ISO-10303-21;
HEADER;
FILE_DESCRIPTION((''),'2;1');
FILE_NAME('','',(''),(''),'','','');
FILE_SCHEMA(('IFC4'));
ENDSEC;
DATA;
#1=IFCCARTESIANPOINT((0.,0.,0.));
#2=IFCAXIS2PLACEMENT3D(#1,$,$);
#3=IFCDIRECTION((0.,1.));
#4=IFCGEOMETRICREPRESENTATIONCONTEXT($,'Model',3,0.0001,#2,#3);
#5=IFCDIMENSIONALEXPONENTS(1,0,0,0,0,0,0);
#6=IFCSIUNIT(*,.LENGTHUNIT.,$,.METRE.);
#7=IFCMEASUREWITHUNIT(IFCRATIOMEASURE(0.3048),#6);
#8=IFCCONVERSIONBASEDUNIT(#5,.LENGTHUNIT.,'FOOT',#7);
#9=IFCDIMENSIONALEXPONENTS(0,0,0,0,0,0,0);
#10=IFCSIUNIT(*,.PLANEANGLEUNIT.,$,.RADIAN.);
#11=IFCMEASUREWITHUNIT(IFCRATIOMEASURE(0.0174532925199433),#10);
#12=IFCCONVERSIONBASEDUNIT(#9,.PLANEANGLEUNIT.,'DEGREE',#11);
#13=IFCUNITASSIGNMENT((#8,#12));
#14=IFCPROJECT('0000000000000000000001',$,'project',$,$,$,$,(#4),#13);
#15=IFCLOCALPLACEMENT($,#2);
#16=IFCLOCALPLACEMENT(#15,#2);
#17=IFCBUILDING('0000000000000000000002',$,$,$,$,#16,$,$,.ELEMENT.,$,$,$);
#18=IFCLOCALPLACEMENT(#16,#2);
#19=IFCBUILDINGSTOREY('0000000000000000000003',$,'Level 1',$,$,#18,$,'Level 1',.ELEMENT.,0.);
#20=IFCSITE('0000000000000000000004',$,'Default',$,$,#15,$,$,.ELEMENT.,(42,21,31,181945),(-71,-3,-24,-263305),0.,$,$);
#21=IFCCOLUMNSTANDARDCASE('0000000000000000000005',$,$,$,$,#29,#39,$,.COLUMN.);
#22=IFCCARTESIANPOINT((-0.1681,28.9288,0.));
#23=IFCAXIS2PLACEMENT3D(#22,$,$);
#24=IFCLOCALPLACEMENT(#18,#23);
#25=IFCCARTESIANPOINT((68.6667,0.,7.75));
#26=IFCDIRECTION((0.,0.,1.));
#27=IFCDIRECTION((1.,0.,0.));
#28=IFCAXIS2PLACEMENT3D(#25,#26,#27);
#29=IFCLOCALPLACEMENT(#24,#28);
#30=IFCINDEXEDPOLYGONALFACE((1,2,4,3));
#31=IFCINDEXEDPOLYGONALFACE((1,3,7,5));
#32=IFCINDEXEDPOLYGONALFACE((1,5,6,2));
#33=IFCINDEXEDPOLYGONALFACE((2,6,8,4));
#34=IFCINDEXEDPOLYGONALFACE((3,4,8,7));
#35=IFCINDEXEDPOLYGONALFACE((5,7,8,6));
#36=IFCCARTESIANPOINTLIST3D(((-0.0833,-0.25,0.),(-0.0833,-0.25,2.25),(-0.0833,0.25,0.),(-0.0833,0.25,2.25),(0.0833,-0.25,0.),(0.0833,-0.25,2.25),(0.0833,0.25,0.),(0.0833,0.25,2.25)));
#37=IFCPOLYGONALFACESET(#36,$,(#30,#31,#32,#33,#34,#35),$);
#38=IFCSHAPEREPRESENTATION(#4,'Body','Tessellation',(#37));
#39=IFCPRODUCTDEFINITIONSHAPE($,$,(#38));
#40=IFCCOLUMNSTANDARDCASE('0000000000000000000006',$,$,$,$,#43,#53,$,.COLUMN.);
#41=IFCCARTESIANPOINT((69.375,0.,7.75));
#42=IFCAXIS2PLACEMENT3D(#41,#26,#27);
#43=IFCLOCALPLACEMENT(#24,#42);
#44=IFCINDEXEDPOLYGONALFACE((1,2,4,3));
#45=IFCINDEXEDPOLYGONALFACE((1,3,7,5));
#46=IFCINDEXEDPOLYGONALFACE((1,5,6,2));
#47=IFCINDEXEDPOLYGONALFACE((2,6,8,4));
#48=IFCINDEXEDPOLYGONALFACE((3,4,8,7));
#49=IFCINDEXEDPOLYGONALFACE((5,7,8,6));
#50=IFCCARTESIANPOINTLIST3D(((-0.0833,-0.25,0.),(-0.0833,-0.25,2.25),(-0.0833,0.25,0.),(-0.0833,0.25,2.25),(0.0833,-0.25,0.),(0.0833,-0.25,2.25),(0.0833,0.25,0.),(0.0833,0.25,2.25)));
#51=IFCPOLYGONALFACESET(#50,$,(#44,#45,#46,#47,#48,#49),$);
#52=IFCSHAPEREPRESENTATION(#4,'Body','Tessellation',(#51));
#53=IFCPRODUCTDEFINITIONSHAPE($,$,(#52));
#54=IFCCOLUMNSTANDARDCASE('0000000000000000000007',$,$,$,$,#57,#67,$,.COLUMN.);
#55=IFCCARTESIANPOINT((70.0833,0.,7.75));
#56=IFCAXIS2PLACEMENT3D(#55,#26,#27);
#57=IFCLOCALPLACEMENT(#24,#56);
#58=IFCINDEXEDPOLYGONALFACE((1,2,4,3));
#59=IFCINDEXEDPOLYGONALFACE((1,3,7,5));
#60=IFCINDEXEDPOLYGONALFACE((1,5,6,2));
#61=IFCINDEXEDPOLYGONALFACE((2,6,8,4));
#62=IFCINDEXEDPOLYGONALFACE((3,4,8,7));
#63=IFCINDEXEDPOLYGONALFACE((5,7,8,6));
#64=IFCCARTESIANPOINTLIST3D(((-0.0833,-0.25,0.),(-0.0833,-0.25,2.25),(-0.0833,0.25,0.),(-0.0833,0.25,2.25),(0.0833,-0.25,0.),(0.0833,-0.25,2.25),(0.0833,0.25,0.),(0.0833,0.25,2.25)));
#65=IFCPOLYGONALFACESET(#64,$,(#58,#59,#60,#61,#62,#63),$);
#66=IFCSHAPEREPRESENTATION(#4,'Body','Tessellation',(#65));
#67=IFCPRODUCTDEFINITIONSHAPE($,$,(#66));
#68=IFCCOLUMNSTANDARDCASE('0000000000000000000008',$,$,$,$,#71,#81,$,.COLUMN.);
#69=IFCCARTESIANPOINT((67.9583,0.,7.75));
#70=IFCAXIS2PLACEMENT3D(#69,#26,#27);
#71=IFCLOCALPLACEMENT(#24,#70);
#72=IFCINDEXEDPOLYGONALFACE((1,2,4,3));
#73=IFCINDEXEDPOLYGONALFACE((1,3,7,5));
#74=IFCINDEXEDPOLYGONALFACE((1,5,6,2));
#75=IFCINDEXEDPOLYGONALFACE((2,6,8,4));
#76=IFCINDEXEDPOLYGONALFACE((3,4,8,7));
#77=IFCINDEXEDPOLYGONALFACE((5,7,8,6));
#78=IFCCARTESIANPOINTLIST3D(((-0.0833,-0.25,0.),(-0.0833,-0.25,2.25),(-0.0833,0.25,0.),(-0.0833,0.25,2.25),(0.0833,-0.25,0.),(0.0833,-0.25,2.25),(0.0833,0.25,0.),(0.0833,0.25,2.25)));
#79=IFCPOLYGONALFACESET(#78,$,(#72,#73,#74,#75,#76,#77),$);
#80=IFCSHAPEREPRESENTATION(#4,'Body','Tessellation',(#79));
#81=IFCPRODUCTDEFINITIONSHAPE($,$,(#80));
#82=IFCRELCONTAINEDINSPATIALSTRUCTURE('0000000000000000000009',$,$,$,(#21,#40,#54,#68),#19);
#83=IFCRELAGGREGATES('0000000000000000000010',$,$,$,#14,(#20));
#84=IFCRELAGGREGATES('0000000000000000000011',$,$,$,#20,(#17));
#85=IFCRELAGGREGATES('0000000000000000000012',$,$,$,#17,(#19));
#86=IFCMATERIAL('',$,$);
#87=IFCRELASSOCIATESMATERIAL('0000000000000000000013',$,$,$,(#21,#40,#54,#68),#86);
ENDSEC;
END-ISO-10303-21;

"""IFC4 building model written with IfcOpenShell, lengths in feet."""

from ifc_helpers import new_model, entity, si_unit, converted_unit, direction, frame, origin, place, context, project, spatial, rectangle, extrude, material, element, save


model = new_model("IFC4")

# Units and contexts
model_context = context("Model", 3, precision=0.0001, world=origin(), true_north=direction((0.0, 1.0)))
ifc_project = project(units=[converted_unit("LENGTHUNIT", "FOOT", entity("IfcRatioMeasure", 0.3048), si_unit("LENGTHUNIT", "METRE"), dimensions=[1, 0, 0, 0, 0, 0, 0]), converted_unit("PLANEANGLEUNIT", "DEGREE", entity("IfcRatioMeasure", 0.0174532925199433), si_unit("PLANEANGLEUNIT", "RADIAN"), dimensions=[0, 0, 0, 0, 0, 0, 0])], contexts=[model_context])

# Site, building, storey
site_placement = place(None, origin())
site = spatial("IfcSite", under=ifc_project, at=site_placement, Name="Default", CompositionType="ELEMENT", RefLatitude=(42, 21, 31, 181945), RefLongitude=(-71, -3, -24, -263305), RefElevation=0.0)
building_placement = place(site_placement, origin())
building = spatial("IfcBuilding", under=site, at=building_placement, CompositionType="ELEMENT")
storey_placement = place(building_placement, origin())
storey = spatial("IfcBuildingStorey", under=building, at=storey_placement, Name="Level 1", LongName="Level 1", CompositionType="ELEMENT", Elevation=0.0)

# Columns
ifc_material_1 = material(Name="")
placement = place(storey_placement, frame((-0.1681, 28.9288, 0.0)))
for number, where, z_axis, x_axis in (
    (1, (68.6667, 0.0, 7.75), (0.0, 0.0, 1.0), (1.0, 0.0, 0.0)),
    (2, (69.375, 0.0, 7.75), (0.0, 0.0, 1.0), (1.0, 0.0, 0.0)),
    (3, (70.0833, 0.0, 7.75), (0.0, 0.0, 1.0), (1.0, 0.0, 0.0)),
    (4, (67.9583, 0.0, 7.75), (0.0, 0.0, 1.0), (1.0, 0.0, 0.0)),
):
    element("IfcColumnStandardCase", number, at=place(placement, frame(where, z_axis=z_axis, x_axis=x_axis)), inside=storey, material=ifc_material_1, PredefinedType="COLUMN", context=model_context, shape_type="SweptSolid", body=[
        extrude(rectangle(XDim=0.1667, YDim=0.5), origin(), (0.0, 0.0, 1.0), 2.25),
    ])

save(model, "model.ifc")
